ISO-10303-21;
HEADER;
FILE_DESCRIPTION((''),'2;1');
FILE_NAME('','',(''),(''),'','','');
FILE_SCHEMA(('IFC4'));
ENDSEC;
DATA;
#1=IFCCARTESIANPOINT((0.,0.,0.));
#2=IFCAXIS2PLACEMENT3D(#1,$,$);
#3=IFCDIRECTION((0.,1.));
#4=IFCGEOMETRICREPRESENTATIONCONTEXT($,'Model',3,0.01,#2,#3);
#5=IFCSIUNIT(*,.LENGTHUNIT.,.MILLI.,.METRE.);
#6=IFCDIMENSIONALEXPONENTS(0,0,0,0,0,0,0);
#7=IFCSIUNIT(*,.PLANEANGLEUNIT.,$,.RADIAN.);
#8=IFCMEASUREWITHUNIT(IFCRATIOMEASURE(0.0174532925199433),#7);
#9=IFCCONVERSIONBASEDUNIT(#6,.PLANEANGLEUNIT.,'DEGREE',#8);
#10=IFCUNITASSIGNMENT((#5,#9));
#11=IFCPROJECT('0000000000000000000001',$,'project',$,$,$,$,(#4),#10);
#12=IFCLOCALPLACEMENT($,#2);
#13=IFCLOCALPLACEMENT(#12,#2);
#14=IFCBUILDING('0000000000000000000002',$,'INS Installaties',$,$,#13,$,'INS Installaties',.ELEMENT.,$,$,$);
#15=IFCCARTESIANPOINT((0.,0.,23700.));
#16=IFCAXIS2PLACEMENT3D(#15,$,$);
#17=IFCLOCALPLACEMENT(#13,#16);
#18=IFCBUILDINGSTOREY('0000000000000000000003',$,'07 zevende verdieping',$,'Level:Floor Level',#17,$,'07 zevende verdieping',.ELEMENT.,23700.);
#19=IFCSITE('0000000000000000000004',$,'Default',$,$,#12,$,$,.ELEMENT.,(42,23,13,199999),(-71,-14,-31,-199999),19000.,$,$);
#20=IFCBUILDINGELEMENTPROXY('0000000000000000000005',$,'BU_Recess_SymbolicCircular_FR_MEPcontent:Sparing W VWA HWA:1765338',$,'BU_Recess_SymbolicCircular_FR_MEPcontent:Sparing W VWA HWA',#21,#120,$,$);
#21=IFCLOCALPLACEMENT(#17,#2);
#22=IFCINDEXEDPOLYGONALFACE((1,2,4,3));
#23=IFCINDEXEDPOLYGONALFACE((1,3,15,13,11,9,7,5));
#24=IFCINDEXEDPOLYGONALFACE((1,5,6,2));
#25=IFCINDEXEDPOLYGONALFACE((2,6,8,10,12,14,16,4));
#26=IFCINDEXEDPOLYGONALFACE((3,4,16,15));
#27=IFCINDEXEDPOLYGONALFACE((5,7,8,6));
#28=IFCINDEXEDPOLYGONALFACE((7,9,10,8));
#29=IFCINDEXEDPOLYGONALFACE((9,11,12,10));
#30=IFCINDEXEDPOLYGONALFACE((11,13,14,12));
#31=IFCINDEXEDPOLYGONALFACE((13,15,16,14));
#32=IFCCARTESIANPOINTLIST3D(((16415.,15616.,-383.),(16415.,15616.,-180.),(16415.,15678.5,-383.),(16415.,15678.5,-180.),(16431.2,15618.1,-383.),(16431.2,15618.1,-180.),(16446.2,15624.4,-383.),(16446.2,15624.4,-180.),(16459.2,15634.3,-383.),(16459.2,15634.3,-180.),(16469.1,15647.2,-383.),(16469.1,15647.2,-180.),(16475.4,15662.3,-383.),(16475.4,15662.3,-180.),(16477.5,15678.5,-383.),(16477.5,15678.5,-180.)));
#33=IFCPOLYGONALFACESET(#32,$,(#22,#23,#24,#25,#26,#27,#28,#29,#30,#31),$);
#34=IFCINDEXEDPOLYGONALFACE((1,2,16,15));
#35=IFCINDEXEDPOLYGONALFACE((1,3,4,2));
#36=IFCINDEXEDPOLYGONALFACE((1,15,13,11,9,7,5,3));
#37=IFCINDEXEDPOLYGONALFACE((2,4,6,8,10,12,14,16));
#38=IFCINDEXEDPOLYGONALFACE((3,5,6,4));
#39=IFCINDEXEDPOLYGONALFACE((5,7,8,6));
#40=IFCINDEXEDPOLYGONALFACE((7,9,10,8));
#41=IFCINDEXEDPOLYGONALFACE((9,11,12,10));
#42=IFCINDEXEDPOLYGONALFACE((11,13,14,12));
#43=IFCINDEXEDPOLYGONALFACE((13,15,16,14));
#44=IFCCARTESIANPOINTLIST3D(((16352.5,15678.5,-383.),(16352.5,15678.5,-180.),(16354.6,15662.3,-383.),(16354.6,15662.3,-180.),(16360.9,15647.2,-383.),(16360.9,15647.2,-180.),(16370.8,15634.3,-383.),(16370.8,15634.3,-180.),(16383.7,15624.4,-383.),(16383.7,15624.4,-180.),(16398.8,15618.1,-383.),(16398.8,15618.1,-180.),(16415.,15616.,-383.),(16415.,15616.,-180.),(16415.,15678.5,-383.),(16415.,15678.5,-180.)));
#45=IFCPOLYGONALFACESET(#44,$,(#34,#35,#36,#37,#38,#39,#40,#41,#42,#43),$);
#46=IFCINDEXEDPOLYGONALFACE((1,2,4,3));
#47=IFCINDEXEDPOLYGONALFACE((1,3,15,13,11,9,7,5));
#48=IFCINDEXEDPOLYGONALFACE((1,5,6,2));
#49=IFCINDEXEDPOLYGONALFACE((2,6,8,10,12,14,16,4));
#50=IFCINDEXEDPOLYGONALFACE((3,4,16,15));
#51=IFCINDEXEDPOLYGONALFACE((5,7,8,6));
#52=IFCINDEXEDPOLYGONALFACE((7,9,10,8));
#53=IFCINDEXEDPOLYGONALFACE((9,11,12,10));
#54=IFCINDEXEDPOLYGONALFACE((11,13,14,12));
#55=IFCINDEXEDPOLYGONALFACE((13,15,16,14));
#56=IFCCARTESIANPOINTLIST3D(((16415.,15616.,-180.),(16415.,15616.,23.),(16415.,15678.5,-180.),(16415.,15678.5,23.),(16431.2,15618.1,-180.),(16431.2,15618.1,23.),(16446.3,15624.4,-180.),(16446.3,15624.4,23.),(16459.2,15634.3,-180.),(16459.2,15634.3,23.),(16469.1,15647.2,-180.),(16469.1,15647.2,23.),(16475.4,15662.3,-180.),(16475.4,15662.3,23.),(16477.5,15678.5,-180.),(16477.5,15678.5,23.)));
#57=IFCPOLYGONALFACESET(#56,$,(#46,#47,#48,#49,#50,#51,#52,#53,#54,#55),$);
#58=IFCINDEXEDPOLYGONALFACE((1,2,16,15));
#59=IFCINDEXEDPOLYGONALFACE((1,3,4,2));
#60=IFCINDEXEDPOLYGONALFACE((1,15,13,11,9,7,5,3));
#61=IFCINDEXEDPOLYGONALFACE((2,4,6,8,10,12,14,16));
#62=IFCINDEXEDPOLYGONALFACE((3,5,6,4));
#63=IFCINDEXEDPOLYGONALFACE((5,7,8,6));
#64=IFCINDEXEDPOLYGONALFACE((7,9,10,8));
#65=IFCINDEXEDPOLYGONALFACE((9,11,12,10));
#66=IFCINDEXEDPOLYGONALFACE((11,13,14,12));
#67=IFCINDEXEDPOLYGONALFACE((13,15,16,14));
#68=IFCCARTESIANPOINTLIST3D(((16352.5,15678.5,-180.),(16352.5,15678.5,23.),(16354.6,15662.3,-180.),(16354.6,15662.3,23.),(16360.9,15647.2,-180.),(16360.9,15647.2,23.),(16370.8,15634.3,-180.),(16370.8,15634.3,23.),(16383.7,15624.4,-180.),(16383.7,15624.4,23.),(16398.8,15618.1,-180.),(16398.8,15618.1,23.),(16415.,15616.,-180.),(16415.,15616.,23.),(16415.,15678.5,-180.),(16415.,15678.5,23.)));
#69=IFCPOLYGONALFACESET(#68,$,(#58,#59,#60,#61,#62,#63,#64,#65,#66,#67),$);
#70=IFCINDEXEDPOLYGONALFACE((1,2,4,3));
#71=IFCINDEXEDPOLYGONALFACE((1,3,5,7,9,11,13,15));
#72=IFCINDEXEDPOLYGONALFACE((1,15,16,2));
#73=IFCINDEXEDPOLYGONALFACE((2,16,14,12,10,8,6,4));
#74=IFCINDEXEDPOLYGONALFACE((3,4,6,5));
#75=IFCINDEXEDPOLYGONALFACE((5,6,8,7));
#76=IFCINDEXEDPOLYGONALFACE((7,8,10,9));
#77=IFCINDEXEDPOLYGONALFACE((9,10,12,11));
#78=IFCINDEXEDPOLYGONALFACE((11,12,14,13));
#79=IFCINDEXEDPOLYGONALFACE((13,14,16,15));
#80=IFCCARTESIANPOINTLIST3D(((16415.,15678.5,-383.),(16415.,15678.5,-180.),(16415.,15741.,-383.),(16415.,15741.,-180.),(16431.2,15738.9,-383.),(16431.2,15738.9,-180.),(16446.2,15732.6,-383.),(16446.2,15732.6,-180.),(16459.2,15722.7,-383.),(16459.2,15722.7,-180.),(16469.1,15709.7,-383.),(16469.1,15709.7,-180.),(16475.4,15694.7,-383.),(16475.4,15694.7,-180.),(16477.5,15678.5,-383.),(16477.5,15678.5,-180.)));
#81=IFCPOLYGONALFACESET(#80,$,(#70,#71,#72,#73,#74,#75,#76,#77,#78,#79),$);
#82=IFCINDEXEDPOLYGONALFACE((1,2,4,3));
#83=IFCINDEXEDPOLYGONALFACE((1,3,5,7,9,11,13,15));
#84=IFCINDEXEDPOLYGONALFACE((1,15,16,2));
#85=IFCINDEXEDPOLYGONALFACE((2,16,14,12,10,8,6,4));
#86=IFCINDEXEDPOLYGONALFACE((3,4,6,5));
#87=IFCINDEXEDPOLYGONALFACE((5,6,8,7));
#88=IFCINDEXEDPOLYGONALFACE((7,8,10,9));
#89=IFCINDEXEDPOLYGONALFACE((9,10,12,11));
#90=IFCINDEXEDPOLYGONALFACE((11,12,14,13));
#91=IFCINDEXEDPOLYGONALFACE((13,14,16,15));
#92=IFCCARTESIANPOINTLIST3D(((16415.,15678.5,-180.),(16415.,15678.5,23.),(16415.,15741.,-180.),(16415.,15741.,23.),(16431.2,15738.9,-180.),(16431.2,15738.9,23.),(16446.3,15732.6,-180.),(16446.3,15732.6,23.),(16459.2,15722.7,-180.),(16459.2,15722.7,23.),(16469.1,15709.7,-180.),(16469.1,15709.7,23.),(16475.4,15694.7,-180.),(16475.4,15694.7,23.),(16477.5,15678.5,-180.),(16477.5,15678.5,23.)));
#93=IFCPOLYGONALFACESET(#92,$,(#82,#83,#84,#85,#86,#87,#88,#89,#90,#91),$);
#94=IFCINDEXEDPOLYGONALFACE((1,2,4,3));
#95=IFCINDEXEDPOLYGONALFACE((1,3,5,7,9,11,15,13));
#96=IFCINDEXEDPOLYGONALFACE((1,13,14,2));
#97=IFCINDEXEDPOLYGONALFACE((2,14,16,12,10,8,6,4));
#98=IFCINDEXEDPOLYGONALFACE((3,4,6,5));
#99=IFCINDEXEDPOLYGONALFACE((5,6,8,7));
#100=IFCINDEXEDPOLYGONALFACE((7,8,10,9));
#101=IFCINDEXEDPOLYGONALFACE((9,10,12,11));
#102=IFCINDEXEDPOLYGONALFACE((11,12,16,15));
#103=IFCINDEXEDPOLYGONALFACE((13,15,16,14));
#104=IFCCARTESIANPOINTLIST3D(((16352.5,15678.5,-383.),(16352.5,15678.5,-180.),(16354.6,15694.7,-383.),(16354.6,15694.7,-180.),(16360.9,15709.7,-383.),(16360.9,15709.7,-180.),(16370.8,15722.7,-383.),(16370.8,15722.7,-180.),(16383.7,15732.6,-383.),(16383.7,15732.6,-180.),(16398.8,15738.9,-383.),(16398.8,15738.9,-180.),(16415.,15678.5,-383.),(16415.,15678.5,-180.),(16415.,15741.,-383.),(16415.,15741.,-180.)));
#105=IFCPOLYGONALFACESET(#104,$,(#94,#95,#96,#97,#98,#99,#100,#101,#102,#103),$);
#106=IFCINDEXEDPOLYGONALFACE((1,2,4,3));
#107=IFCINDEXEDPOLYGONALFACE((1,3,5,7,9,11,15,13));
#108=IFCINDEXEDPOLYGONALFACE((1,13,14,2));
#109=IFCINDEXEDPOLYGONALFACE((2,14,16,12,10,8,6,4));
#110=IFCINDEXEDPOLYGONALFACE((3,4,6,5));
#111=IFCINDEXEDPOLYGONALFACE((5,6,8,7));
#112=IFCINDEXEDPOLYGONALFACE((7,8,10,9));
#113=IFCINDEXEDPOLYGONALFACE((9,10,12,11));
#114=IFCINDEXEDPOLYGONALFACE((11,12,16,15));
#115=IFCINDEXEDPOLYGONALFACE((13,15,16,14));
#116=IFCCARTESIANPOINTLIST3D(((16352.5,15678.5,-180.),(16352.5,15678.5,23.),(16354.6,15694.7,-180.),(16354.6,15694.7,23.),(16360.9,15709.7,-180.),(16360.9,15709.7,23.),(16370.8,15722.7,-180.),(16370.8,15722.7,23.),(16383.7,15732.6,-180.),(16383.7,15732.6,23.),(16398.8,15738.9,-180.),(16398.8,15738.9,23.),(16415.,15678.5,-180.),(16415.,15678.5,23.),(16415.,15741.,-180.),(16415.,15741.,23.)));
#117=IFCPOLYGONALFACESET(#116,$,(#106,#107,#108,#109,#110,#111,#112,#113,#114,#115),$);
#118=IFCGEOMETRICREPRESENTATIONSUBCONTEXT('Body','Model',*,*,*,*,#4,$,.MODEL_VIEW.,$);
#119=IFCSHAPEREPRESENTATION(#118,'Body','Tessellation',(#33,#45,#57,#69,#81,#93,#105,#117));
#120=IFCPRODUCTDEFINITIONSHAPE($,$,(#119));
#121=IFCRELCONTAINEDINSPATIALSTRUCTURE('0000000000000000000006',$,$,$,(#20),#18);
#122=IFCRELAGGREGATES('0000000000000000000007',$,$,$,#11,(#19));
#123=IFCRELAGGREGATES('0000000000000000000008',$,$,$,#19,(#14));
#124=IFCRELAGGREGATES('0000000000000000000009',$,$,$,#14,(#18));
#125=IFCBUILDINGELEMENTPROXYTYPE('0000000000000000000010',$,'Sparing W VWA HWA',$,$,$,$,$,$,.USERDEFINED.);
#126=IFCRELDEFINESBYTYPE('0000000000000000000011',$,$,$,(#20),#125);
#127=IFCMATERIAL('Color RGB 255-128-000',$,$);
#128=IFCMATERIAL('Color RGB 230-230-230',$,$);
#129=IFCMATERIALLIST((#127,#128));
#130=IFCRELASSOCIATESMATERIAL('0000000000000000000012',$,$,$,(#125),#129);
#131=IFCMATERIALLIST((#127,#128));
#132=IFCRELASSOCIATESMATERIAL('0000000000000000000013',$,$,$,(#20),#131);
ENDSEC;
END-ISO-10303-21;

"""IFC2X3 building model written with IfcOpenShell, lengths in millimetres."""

from ifc_helpers import new_model, entity, si_unit, converted_unit, direction, frame, frame_2d, origin, place, context, subcontext, project, spatial, polyline, circle_curve, parameter, trimmed, segment, composite_curve, outline, extrude, source, transform, mapped, material, material_list, type_object, type_shapes, element, save


model = new_model("IFC2X3")

# Units and contexts
model_context = context("Model", 3, precision=0.01, world=origin(), true_north=direction((0.0, 1.0)))
body_context = subcontext(model_context, "Body", "Model", "MODEL_VIEW")
ifc_project = project(units=[si_unit("LENGTHUNIT", "METRE", prefix="MILLI"), converted_unit("PLANEANGLEUNIT", "DEGREE", entity("IfcRatioMeasure", 0.0174532925199433), si_unit("PLANEANGLEUNIT", "RADIAN"), dimensions=[0, 0, 0, 0, 0, 0, 0])], contexts=[model_context])

# Site, building, storey
site_placement = place(None, origin())
site = spatial("IfcSite", under=ifc_project, at=site_placement, Name="Default", CompositionType="ELEMENT", RefLatitude=(42, 23, 13, 199999), RefLongitude=(-71, -14, -31, -199999), RefElevation=19000.0)
building_placement = place(site_placement, origin())
building = spatial("IfcBuilding", under=site, at=building_placement, Name="INS Installaties", LongName="INS Installaties", CompositionType="ELEMENT")
storey_placement = place(building_placement, frame((0.0, 0.0, 23700.0)))
storey = spatial("IfcBuildingStorey", under=building, at=storey_placement, Name="07 zevende verdieping", ObjectType="Level:Floor Level", LongName="07 zevende verdieping", CompositionType="ELEMENT", Elevation=23700.0)

# Building element proxy
ifc_material_1 = material(Name="Color RGB 255-128-000")
ifc_material_2 = material(Name="Color RGB 230-230-230")
ifc_material_list_1 = material_list([ifc_material_1, ifc_material_2])
building_element_proxy_type_1 = type_object("IfcBuildingElementProxyType", Name="Sparing W VWA HWA", PredefinedType="USERDEFINED", material=ifc_material_list_1)
shared_shape_1 = source(origin(), body_context, "Body", "SweptSolid", [
    extrude(outline(composite_curve([segment(polyline([(-41.7, -20.8), (20.8, -20.8)]), True, "CONTINUOUS"), segment(polyline([(20.8, -20.8), (20.8, 41.7)]), True, "CONTINUOUS"), segment(trimmed(circle_curve(frame_2d((20.8, -20.8), x_axis=(1.0, 0.0)), 62.5), [parameter(90.0)], [parameter(180.0)], True, "PARAMETER"), True, "CONTINUOUS")], self_intersect=False)), frame((20.8, -20.8, -403.0), z_axis=(0.0, 0.0, 1.0), x_axis=(-1.0, 0.0, 0.0)), (0.0, 0.0, 1.0), 203.0),
    extrude(outline(composite_curve([segment(trimmed(circle_curve(frame_2d((20.8, 20.8), x_axis=(1.0, 0.0)), 62.5), [parameter(180.0)], [parameter(270.0)], True, "PARAMETER"), True, "CONTINUOUS"), segment(polyline([(20.8, -41.7), (20.8, 20.8)]), True, "CONTINUOUS"), segment(polyline([(20.8, 20.8), (-41.7, 20.8)]), True, "CONTINUOUS")], self_intersect=False)), frame((-20.8, -20.8, -403.0)), (0.0, 0.0, 1.0), 203.0),
    extrude(outline(composite_curve([segment(polyline([(-41.7, -20.8), (20.8, -20.8)]), True, "CONTINUOUS"), segment(polyline([(20.8, -20.8), (20.8, 41.7)]), True, "CONTINUOUS"), segment(trimmed(circle_curve(frame_2d((20.8, -20.8), x_axis=(1.0, 0.0)), 62.5), [parameter(90.0)], [parameter(180.0)], True, "PARAMETER"), True, "CONTINUOUS")], self_intersect=False)), frame((20.8, -20.8, -200.0), z_axis=(0.0, 0.0, 1.0), x_axis=(-1.0, 0.0, 0.0)), (0.0, 0.0, 1.0), 203.0),
    extrude(outline(composite_curve([segment(trimmed(circle_curve(frame_2d((20.8, 20.8), x_axis=(1.0, 0.0)), 62.5), [parameter(180.0)], [parameter(270.0)], True, "PARAMETER"), True, "CONTINUOUS"), segment(polyline([(20.8, -41.7), (20.8, 20.8)]), True, "CONTINUOUS"), segment(polyline([(20.8, 20.8), (-41.7, 20.8)]), True, "CONTINUOUS")], self_intersect=False)), frame((-20.8, -20.8, -200.0)), (0.0, 0.0, 1.0), 203.0),
    extrude(outline(composite_curve([segment(trimmed(circle_curve(frame_2d((20.8, 20.8), x_axis=(1.0, 0.0)), 62.5), [parameter(180.0)], [parameter(270.0)], True, "PARAMETER"), True, "CONTINUOUS"), segment(polyline([(20.8, -41.7), (20.8, 20.8)]), True, "CONTINUOUS"), segment(polyline([(20.8, 20.8), (-41.7, 20.8)]), True, "CONTINUOUS")], self_intersect=False)), frame((20.8, 20.8, -403.0), z_axis=(0.0, 0.0, 1.0), x_axis=(-1.0, 0.0, 0.0)), (0.0, 0.0, 1.0), 203.0),
    extrude(outline(composite_curve([segment(trimmed(circle_curve(frame_2d((20.8, 20.8), x_axis=(1.0, 0.0)), 62.5), [parameter(180.0)], [parameter(270.0)], True, "PARAMETER"), True, "CONTINUOUS"), segment(polyline([(20.8, -41.7), (20.8, 20.8)]), True, "CONTINUOUS"), segment(polyline([(20.8, 20.8), (-41.7, 20.8)]), True, "CONTINUOUS")], self_intersect=False)), frame((20.8, 20.8, -200.0), z_axis=(0.0, 0.0, 1.0), x_axis=(-1.0, 0.0, 0.0)), (0.0, 0.0, 1.0), 203.0),
    extrude(outline(composite_curve([segment(polyline([(-41.7, -20.8), (20.8, -20.8)]), True, "CONTINUOUS"), segment(polyline([(20.8, -20.8), (20.8, 41.7)]), True, "CONTINUOUS"), segment(trimmed(circle_curve(frame_2d((20.8, -20.8), x_axis=(1.0, 0.0)), 62.5), [parameter(90.0)], [parameter(180.0)], True, "PARAMETER"), True, "CONTINUOUS")], self_intersect=False)), frame((-20.8, 20.8, -403.0)), (0.0, 0.0, 1.0), 203.0),
    extrude(outline(composite_curve([segment(polyline([(-41.7, -20.8), (20.8, -20.8)]), True, "CONTINUOUS"), segment(polyline([(20.8, -20.8), (20.8, 41.7)]), True, "CONTINUOUS"), segment(trimmed(circle_curve(frame_2d((20.8, -20.8), x_axis=(1.0, 0.0)), 62.5), [parameter(90.0)], [parameter(180.0)], True, "PARAMETER"), True, "CONTINUOUS")], self_intersect=False)), frame((-20.8, 20.8, -200.0)), (0.0, 0.0, 1.0), 203.0),
])
type_shapes(building_element_proxy_type_1, [shared_shape_1])
ifc_material_list_2 = material_list([ifc_material_1, ifc_material_2])
proxy_1_placement = place(storey_placement, frame((16415.0, 15678.5, 20.0)))
element("IfcBuildingElementProxy", 1, at=proxy_1_placement, inside=storey, type_object=building_element_proxy_type_1, material=ifc_material_list_2, Name="BU_Recess_SymbolicCircular_FR_MEPcontent:Sparing W VWA HWA:1765338", ObjectType="BU_Recess_SymbolicCircular_FR_MEPcontent:Sparing W VWA HWA", context=body_context, shape_type="MappedRepresentation", body=[
    mapped(shared_shape_1, transform((0.0, 0.0, 0.0), scale=1.0)),
])

save(model, "model.ifc")
